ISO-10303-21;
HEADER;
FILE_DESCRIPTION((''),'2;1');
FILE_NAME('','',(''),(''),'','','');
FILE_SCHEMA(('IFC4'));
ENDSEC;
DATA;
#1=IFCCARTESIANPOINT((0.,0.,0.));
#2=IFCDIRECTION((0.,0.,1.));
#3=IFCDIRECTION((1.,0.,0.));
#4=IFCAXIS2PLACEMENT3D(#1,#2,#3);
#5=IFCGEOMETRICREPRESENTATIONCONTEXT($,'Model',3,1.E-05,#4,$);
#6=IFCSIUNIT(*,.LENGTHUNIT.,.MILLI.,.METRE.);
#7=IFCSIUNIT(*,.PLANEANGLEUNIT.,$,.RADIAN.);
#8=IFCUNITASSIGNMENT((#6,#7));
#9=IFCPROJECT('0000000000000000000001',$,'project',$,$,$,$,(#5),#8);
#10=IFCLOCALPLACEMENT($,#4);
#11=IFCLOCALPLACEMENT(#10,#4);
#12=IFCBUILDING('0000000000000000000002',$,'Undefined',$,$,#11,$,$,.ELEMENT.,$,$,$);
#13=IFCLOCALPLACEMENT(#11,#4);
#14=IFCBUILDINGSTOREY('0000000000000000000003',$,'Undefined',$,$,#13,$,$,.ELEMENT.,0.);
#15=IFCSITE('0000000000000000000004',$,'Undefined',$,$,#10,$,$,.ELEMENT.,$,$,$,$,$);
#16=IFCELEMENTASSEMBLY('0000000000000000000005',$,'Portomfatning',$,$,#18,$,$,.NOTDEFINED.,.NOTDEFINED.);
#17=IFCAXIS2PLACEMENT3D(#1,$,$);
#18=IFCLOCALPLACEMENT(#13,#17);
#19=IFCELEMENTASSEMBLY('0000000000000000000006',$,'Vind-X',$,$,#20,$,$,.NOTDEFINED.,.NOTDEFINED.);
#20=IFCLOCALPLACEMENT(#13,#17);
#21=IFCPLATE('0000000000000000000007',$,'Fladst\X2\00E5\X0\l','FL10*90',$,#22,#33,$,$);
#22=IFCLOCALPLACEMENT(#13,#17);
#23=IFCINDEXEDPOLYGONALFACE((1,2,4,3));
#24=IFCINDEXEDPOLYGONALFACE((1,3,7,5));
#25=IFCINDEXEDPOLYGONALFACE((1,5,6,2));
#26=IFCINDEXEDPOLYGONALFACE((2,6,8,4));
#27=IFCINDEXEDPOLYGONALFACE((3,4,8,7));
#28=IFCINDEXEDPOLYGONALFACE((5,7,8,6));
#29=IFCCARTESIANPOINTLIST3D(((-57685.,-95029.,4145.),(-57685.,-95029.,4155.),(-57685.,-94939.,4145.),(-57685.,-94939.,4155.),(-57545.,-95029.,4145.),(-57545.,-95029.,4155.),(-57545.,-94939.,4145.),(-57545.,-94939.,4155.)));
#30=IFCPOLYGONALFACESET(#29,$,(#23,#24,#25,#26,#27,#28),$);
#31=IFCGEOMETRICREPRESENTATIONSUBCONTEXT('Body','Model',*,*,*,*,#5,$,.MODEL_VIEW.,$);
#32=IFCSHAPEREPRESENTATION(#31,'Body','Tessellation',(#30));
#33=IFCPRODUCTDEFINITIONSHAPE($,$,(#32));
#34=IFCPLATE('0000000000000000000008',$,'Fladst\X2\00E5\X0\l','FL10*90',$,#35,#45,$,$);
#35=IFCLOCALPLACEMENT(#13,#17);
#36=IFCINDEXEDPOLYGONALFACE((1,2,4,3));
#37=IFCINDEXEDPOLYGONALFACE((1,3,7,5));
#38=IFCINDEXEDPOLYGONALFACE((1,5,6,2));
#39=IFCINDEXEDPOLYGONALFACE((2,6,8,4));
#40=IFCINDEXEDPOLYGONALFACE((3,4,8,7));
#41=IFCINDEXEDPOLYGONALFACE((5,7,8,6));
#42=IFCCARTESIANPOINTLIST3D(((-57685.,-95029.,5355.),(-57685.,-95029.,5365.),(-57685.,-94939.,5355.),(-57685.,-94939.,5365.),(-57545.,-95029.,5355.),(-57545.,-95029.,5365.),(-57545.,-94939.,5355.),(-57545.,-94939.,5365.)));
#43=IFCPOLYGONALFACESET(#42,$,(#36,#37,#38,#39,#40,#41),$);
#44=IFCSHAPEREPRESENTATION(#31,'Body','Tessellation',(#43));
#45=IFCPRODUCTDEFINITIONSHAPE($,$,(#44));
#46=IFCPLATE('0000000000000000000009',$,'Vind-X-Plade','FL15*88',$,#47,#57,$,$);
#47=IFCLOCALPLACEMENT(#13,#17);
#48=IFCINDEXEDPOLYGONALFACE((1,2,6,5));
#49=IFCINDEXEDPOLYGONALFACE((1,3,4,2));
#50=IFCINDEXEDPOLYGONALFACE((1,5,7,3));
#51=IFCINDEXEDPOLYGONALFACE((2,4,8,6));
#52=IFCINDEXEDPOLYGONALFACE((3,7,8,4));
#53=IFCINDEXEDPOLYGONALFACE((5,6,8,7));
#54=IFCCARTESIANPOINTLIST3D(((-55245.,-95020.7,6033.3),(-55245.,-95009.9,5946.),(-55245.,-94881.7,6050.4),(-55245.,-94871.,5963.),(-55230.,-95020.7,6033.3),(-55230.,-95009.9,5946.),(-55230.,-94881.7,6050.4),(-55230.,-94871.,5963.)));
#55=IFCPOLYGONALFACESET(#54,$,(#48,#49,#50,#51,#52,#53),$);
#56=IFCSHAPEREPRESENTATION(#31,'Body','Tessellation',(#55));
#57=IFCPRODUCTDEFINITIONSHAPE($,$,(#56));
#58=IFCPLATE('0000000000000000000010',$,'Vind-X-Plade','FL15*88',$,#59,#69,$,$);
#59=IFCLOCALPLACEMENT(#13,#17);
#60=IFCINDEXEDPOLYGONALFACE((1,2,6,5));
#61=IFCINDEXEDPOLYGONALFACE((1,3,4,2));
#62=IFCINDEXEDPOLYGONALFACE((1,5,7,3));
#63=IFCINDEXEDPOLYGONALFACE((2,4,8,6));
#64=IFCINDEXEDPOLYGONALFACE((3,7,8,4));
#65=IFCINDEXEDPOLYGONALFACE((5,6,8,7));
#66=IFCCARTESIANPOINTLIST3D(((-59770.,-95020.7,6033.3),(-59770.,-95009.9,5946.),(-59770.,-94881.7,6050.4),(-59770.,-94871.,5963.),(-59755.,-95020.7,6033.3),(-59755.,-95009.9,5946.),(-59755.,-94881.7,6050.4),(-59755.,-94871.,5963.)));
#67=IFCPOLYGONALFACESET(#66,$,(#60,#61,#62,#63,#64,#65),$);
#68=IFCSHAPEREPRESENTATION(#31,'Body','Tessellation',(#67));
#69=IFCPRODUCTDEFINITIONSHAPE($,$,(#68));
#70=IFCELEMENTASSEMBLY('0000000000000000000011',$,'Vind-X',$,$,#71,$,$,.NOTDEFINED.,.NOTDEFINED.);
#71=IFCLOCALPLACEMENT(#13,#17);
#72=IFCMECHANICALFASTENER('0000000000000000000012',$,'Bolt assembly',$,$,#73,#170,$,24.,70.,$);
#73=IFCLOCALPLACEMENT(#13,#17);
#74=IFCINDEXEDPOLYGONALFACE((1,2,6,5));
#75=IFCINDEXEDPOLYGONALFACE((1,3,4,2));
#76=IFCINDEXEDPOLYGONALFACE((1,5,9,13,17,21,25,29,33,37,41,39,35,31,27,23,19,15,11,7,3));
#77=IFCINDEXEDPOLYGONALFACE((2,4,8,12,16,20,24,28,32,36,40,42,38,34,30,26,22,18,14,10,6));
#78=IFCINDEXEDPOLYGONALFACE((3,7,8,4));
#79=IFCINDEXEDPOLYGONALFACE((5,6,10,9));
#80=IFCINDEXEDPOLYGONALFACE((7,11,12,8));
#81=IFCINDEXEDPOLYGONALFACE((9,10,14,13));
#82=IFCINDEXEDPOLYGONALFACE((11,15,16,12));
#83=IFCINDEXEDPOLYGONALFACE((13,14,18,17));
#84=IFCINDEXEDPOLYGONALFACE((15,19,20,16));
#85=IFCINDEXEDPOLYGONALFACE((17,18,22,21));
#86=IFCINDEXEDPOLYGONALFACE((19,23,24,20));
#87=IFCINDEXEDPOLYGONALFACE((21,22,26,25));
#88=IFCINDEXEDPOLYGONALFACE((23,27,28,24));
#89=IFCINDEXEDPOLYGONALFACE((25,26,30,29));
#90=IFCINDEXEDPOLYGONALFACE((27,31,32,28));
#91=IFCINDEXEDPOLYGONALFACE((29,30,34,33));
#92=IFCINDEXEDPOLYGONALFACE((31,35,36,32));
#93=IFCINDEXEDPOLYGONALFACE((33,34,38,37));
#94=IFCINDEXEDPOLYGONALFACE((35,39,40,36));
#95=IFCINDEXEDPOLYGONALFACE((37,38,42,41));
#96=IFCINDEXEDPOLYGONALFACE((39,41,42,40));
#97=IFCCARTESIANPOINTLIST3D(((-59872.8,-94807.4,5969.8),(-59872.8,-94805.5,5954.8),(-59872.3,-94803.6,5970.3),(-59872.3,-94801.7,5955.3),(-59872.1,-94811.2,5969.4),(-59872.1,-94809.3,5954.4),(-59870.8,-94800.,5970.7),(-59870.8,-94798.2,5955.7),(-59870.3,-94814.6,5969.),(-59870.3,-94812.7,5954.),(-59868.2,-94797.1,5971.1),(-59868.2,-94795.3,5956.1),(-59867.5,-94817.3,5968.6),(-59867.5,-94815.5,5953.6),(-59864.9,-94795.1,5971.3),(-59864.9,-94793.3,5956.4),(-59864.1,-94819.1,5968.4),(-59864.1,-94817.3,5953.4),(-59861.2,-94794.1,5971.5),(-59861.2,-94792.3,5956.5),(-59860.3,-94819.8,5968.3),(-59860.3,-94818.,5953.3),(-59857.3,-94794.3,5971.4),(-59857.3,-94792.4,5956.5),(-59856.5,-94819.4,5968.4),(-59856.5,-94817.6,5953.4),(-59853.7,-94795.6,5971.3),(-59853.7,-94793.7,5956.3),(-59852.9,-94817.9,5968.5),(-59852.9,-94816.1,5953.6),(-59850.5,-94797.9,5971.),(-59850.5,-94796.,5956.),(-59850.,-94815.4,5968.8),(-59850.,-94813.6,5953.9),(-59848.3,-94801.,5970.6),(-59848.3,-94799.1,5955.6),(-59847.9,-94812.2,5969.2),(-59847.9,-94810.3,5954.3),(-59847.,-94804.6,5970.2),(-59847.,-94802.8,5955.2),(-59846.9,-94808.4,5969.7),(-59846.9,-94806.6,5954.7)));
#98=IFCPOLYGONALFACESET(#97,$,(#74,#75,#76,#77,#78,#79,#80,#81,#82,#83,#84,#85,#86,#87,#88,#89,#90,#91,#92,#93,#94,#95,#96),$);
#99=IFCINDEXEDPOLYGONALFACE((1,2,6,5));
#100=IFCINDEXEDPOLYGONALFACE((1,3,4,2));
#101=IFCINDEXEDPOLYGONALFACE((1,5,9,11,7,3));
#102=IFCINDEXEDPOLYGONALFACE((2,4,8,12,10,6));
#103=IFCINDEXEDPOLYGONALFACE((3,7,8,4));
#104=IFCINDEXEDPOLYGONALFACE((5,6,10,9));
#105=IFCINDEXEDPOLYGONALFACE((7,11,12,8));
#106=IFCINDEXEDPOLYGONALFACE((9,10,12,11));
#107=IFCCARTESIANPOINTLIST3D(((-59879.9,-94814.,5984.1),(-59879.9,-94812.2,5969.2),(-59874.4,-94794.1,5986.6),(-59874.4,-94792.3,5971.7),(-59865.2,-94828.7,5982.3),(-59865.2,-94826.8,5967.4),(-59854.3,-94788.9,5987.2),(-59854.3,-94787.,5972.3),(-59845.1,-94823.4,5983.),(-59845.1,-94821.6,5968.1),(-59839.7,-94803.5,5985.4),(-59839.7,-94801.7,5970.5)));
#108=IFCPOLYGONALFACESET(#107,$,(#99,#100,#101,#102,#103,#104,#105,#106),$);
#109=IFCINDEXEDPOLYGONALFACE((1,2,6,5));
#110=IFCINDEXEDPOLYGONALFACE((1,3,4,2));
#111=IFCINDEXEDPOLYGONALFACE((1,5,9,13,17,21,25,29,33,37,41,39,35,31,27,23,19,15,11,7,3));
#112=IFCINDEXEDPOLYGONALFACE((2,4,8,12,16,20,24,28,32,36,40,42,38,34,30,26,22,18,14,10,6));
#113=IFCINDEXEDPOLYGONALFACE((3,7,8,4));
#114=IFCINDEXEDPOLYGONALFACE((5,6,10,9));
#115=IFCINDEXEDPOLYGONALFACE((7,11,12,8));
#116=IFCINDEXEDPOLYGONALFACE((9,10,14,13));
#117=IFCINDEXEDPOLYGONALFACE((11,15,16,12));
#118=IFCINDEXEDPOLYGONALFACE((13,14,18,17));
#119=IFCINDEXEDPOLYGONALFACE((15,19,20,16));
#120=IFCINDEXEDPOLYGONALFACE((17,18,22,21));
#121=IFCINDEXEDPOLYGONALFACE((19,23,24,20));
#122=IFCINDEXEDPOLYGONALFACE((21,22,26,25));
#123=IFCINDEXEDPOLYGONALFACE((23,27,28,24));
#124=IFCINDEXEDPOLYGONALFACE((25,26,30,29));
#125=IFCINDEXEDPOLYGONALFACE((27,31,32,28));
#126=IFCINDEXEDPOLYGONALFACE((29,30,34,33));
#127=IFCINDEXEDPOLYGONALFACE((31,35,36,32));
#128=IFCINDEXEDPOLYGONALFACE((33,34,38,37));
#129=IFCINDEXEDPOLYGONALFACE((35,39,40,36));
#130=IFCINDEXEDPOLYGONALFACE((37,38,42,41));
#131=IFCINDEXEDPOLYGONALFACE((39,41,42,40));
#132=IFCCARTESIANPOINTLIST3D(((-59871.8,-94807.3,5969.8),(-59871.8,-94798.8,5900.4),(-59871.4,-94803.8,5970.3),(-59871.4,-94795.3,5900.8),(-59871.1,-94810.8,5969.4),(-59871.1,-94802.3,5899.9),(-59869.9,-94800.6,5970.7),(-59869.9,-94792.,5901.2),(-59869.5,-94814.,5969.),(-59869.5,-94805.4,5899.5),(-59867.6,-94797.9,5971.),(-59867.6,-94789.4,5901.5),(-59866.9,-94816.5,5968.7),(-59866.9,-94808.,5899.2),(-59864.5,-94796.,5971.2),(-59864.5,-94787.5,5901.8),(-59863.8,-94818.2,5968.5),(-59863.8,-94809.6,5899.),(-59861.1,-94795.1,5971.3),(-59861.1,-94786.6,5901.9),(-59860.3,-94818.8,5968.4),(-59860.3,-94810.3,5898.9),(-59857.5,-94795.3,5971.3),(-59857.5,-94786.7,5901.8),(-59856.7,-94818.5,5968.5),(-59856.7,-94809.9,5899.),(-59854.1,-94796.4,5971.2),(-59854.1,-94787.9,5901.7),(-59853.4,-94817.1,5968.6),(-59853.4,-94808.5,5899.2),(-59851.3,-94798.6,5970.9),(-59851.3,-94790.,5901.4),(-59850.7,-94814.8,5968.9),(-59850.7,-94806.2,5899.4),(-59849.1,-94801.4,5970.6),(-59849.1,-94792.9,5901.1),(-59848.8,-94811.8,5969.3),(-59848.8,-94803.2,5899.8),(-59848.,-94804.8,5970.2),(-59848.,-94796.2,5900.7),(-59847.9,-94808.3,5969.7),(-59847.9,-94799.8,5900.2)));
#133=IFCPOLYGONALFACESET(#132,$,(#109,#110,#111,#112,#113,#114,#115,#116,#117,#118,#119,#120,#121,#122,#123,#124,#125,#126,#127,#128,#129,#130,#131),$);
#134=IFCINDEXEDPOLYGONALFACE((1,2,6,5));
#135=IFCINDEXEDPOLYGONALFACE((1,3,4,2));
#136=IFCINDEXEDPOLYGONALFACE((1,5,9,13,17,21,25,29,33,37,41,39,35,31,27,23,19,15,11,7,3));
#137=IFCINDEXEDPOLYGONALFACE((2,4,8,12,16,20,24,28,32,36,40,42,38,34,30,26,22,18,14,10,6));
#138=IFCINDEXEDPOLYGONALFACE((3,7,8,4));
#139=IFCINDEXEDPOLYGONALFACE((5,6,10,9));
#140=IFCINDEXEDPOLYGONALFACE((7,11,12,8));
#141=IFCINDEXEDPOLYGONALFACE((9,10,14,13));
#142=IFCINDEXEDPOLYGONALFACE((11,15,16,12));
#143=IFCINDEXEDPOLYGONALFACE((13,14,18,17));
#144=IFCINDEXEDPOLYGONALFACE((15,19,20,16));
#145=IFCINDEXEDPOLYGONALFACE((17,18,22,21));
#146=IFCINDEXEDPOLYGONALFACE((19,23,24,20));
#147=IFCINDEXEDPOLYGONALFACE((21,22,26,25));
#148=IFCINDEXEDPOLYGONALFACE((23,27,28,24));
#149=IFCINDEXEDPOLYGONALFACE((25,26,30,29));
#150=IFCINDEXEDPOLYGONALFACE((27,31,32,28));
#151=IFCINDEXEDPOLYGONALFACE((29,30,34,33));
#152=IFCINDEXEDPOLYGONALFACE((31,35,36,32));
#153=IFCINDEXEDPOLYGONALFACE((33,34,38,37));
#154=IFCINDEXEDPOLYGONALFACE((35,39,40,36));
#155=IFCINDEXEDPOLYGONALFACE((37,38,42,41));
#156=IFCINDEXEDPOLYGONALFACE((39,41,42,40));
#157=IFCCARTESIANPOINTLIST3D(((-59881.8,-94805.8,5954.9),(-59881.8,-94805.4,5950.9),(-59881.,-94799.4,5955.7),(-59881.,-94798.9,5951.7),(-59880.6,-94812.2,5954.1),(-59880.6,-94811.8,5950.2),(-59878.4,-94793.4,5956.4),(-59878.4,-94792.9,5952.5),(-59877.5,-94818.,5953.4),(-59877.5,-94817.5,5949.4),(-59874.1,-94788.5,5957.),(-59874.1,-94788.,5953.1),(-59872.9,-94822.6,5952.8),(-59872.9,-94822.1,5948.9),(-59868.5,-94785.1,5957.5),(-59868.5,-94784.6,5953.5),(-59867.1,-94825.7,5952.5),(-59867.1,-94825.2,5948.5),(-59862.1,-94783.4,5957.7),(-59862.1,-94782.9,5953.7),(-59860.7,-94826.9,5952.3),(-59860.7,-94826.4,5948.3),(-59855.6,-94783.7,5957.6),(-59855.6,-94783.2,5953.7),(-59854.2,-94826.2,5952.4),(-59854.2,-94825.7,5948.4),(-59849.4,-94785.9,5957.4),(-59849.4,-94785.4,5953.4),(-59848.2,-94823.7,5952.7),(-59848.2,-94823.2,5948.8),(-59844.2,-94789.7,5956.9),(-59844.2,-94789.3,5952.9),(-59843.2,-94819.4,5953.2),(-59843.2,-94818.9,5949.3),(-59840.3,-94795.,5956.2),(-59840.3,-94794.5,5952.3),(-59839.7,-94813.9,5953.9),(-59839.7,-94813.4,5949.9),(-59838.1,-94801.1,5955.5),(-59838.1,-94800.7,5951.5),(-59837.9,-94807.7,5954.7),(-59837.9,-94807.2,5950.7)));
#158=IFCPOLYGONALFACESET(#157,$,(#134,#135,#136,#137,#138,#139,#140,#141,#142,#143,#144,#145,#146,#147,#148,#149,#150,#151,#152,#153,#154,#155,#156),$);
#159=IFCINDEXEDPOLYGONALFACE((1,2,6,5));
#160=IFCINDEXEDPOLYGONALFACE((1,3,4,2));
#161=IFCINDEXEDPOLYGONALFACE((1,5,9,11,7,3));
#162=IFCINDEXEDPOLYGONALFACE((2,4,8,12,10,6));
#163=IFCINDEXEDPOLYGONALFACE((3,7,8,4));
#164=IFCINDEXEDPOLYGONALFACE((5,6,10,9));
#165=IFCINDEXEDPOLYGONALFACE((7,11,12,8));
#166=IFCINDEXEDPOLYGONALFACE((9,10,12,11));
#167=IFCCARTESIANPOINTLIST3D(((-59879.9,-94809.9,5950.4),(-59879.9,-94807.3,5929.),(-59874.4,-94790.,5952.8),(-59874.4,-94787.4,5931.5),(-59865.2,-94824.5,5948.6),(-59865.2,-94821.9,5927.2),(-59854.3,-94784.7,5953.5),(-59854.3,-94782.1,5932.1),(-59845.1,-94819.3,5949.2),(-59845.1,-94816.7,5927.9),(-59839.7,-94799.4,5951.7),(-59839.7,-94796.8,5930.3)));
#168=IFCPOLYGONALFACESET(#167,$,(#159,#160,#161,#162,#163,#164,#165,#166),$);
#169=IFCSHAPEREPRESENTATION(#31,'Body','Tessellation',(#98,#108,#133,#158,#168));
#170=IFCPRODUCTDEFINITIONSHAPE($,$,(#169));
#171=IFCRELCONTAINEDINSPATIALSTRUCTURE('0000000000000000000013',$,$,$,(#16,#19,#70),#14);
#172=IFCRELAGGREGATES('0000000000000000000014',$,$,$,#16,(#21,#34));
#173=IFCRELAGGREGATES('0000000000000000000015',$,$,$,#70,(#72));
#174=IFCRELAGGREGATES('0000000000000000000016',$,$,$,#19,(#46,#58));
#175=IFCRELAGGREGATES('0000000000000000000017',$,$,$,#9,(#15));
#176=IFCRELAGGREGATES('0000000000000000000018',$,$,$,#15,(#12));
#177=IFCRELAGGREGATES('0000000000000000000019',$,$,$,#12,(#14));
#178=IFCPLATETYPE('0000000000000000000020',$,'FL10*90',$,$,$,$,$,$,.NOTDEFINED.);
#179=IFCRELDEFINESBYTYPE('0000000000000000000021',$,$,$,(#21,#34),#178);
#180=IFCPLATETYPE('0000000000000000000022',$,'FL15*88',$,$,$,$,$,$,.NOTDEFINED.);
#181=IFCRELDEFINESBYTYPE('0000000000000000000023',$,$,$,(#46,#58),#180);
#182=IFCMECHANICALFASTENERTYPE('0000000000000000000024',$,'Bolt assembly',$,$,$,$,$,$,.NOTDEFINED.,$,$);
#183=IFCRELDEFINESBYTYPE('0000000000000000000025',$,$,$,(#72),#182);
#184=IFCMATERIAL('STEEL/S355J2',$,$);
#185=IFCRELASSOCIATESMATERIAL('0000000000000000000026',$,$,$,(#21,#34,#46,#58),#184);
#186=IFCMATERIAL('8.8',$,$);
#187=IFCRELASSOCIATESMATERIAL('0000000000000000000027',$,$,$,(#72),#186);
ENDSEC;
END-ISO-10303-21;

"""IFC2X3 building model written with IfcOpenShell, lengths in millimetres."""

from ifc_helpers import new_model, si_unit, frame, origin_with_axes, origin_2d_with_axis, place, context, subcontext, project, spatial, polyline, circle, outline, extrude, source, transform, mapped, material, type_object, element, aggregate, save


model = new_model("IFC2X3")

# Units and contexts
model_context = context("Model", 3, precision=1e-05, world=origin_with_axes())
body_context = subcontext(model_context, "Body", "Model", "MODEL_VIEW")
ifc_project = project(units=[si_unit("LENGTHUNIT", "METRE", prefix="MILLI"), si_unit("PLANEANGLEUNIT", "RADIAN")], contexts=[model_context])

# Site, building, storey
site_placement = place(None, origin_with_axes())
site = spatial("IfcSite", under=ifc_project, at=site_placement, Name="Undefined", CompositionType="ELEMENT")
building_placement = place(site_placement, origin_with_axes())
building = spatial("IfcBuilding", under=site, at=building_placement, Name="Undefined", CompositionType="ELEMENT")
storey_placement = place(building_placement, origin_with_axes())
storey = spatial("IfcBuildingStorey", under=building, at=storey_placement, Name="Undefined", CompositionType="ELEMENT", Elevation=0.0)

# Element assembly
assembly_1_placement = place(storey_placement, origin_with_axes())
assembly_1 = element("IfcElementAssembly", 1, at=assembly_1_placement, inside=storey, Name="Portomfatning", AssemblyPlace="NOTDEFINED", PredefinedType="NOTDEFINED")

# Element assembly
assembly_2_placement = place(storey_placement, origin_with_axes())
assembly_2 = element("IfcElementAssembly", 2, at=assembly_2_placement, inside=storey, Name="Vind-X", AssemblyPlace="NOTDEFINED", PredefinedType="NOTDEFINED")

# Shared definitions
ifc_material_1 = material(Name="STEEL/S355J2")

# Plates
plate_type_1 = type_object("IfcPlateType", Name="FL10*90", PredefinedType="NOTDEFINED")
plate_1_placement = place(assembly_1_placement, frame((-57545.0, -94984.0, 4150.0), z_axis=(0.0, 0.0, 1.0), x_axis=(-1.0, 0.0, 0.0)))
plate_1 = element("IfcPlate", 3, at=plate_1_placement, type_object=plate_type_1, material=ifc_material_1, Name="Fladstål", Description="FL10*90", context=body_context, shape_type="SweptSolid", body=[
    extrude(outline(polyline([(0.0, -45.0), (0.0, 45.0), (140.0, 45.0), (140.0, -45.0), (0.0, -45.0)])), frame((0.0, 0.0, -5.0), z_axis=(0.0, 0.0, 1.0), x_axis=(1.0, 0.0, 0.0)), (0.0, 0.0, 1.0), 10.0),
])
plate_2_placement = place(assembly_1_placement, frame((-57545.0, -94984.0, 5360.0), z_axis=(0.0, 0.0, -1.0), x_axis=(-1.0, 0.0, 0.0)))
plate_2 = element("IfcPlate", 4, at=plate_2_placement, type_object=plate_type_1, material=ifc_material_1, Name="Fladstål", Description="FL10*90", context=body_context, shape_type="SweptSolid", body=[
    extrude(outline(polyline([(0.0, -45.0), (0.0, 45.0), (140.0, 45.0), (140.0, -45.0), (0.0, -45.0)])), frame((0.0, 0.0, -5.0), z_axis=(0.0, 0.0, 1.0), x_axis=(1.0, 0.0, 0.0)), (0.0, 0.0, 1.0), 10.0),
])
plate_type_2 = type_object("IfcPlateType", Name="FL15*88", PredefinedType="NOTDEFINED")
plate_3_placement = place(assembly_2_placement, frame((-55237.5, -94881.7, 6050.4), z_axis=(1.0, 0.0, 0.0), x_axis=(0.0, -0.992546, -0.121869)))
plate_3 = element("IfcPlate", 5, at=plate_3_placement, type_object=plate_type_2, material=ifc_material_1, Name="Vind-X-Plade", Description="FL15*88", context=body_context, shape_type="SweptSolid", body=[
    extrude(outline(polyline([(0.0, 0.0), (140.0, 0.0), (140.0, 88.0), (0.0, 88.0), (0.0, 0.0)])), frame((0.0, 0.0, -7.5), z_axis=(0.0, 0.0, 1.0), x_axis=(1.0, 0.0, 0.0)), (0.0, 0.0, 1.0), 15.0),
])
plate_4_placement = place(assembly_2_placement, frame((-59762.5, -95020.7, 6033.3), z_axis=(-1.0, 0.0, 0.0), x_axis=(0.0, 0.992546, 0.121869)))
plate_4 = element("IfcPlate", 6, at=plate_4_placement, type_object=plate_type_2, material=ifc_material_1, Name="Vind-X-Plade", Description="FL15*88", context=body_context, shape_type="SweptSolid", body=[
    extrude(outline(polyline([(0.0, 0.0), (140.0, 0.0), (140.0, 88.0), (0.0, 88.0), (0.0, 0.0)])), frame((0.0, 0.0, -7.5), z_axis=(0.0, 0.0, 1.0), x_axis=(1.0, 0.0, 0.0)), (0.0, 0.0, 1.0), 15.0),
])

# Shared definitions
ifc_material_2 = material(Name="8.8")
mechanical_fastener_type = type_object("IfcMechanicalFastenerType", Name="Bolt assembly")
aggregate(assembly_1, [plate_1, plate_2])

# Element assembly, mechanical fastener
assembly_3_placement = place(storey_placement, origin_with_axes())
assembly_3 = element("IfcElementAssembly", 7, at=assembly_3_placement, inside=storey, Name="Vind-X", AssemblyPlace="NOTDEFINED", PredefinedType="NOTDEFINED")
shared_shape_1 = source(origin_with_axes(), body_context, "Body", "SweptSolid", [
    extrude(circle(Radius=13.0, at=origin_2d_with_axis()), frame((0.0, 0.0, 0.0), z_axis=(0.0, 1.0, 0.0), x_axis=(1.0, 0.0, 0.0)), (0.0, 0.0, 1.0), 15.1),
    extrude(outline(polyline([(18.0, -10.4), (18.0, 10.4), (0.0, 20.8), (-18.0, 10.4), (-18.0, -10.4), (0.0, -20.8), (18.0, -10.4)])), frame((0.0, -15.0, 0.0), z_axis=(0.0, 1.0, 0.0), x_axis=(1.0, 0.0, 0.0)), (0.0, 0.0, 1.0), 15.0),
    extrude(circle(Radius=12.0, at=origin_2d_with_axis()), frame((0.0, 0.0, 0.0), z_axis=(0.0, 1.0, 0.0), x_axis=(1.0, 0.0, 0.0)), (0.0, 0.0, 1.0), 70.0),
    extrude(circle(Radius=22.0, at=origin_2d_with_axis()), frame((0.0, 15.0, 0.0), z_axis=(0.0, 1.0, 0.0), x_axis=(1.0, 0.0, 0.0)), (0.0, 0.0, 1.0), 4.0),
    extrude(outline(polyline([(18.0, -10.4), (18.0, 10.4), (0.0, 20.8), (-18.0, 10.4), (-18.0, -10.4), (0.0, -20.8), (18.0, -10.4)])), frame((0.0, 19.0, 0.0), z_axis=(0.0, 1.0, 0.0), x_axis=(1.0, 0.0, 0.0)), (0.0, 0.0, 1.0), 21.5),
])
mechanical_fastener_1_placement = place(assembly_3_placement, frame((-59859.8, -94806.9, 5969.9), z_axis=(-0.704031, 0.704876, 0.086548), x_axis=(0.71017, 0.698783, 0.0858)))
mechanical_fastener_1 = element("IfcMechanicalFastener", 8, at=mechanical_fastener_1_placement, type_object=mechanical_fastener_type, material=ifc_material_2, Name="Bolt assembly", NominalDiameter=24.0, NominalLength=70.0, context=body_context, shape_type="MappedRepresentation", body=[
    mapped(shared_shape_1, transform((0.0, 0.0, 0.0))),
])
aggregate(assembly_3, [mechanical_fastener_1])

aggregate(assembly_2, [plate_3, plate_4])

save(model, "model.ifc")
